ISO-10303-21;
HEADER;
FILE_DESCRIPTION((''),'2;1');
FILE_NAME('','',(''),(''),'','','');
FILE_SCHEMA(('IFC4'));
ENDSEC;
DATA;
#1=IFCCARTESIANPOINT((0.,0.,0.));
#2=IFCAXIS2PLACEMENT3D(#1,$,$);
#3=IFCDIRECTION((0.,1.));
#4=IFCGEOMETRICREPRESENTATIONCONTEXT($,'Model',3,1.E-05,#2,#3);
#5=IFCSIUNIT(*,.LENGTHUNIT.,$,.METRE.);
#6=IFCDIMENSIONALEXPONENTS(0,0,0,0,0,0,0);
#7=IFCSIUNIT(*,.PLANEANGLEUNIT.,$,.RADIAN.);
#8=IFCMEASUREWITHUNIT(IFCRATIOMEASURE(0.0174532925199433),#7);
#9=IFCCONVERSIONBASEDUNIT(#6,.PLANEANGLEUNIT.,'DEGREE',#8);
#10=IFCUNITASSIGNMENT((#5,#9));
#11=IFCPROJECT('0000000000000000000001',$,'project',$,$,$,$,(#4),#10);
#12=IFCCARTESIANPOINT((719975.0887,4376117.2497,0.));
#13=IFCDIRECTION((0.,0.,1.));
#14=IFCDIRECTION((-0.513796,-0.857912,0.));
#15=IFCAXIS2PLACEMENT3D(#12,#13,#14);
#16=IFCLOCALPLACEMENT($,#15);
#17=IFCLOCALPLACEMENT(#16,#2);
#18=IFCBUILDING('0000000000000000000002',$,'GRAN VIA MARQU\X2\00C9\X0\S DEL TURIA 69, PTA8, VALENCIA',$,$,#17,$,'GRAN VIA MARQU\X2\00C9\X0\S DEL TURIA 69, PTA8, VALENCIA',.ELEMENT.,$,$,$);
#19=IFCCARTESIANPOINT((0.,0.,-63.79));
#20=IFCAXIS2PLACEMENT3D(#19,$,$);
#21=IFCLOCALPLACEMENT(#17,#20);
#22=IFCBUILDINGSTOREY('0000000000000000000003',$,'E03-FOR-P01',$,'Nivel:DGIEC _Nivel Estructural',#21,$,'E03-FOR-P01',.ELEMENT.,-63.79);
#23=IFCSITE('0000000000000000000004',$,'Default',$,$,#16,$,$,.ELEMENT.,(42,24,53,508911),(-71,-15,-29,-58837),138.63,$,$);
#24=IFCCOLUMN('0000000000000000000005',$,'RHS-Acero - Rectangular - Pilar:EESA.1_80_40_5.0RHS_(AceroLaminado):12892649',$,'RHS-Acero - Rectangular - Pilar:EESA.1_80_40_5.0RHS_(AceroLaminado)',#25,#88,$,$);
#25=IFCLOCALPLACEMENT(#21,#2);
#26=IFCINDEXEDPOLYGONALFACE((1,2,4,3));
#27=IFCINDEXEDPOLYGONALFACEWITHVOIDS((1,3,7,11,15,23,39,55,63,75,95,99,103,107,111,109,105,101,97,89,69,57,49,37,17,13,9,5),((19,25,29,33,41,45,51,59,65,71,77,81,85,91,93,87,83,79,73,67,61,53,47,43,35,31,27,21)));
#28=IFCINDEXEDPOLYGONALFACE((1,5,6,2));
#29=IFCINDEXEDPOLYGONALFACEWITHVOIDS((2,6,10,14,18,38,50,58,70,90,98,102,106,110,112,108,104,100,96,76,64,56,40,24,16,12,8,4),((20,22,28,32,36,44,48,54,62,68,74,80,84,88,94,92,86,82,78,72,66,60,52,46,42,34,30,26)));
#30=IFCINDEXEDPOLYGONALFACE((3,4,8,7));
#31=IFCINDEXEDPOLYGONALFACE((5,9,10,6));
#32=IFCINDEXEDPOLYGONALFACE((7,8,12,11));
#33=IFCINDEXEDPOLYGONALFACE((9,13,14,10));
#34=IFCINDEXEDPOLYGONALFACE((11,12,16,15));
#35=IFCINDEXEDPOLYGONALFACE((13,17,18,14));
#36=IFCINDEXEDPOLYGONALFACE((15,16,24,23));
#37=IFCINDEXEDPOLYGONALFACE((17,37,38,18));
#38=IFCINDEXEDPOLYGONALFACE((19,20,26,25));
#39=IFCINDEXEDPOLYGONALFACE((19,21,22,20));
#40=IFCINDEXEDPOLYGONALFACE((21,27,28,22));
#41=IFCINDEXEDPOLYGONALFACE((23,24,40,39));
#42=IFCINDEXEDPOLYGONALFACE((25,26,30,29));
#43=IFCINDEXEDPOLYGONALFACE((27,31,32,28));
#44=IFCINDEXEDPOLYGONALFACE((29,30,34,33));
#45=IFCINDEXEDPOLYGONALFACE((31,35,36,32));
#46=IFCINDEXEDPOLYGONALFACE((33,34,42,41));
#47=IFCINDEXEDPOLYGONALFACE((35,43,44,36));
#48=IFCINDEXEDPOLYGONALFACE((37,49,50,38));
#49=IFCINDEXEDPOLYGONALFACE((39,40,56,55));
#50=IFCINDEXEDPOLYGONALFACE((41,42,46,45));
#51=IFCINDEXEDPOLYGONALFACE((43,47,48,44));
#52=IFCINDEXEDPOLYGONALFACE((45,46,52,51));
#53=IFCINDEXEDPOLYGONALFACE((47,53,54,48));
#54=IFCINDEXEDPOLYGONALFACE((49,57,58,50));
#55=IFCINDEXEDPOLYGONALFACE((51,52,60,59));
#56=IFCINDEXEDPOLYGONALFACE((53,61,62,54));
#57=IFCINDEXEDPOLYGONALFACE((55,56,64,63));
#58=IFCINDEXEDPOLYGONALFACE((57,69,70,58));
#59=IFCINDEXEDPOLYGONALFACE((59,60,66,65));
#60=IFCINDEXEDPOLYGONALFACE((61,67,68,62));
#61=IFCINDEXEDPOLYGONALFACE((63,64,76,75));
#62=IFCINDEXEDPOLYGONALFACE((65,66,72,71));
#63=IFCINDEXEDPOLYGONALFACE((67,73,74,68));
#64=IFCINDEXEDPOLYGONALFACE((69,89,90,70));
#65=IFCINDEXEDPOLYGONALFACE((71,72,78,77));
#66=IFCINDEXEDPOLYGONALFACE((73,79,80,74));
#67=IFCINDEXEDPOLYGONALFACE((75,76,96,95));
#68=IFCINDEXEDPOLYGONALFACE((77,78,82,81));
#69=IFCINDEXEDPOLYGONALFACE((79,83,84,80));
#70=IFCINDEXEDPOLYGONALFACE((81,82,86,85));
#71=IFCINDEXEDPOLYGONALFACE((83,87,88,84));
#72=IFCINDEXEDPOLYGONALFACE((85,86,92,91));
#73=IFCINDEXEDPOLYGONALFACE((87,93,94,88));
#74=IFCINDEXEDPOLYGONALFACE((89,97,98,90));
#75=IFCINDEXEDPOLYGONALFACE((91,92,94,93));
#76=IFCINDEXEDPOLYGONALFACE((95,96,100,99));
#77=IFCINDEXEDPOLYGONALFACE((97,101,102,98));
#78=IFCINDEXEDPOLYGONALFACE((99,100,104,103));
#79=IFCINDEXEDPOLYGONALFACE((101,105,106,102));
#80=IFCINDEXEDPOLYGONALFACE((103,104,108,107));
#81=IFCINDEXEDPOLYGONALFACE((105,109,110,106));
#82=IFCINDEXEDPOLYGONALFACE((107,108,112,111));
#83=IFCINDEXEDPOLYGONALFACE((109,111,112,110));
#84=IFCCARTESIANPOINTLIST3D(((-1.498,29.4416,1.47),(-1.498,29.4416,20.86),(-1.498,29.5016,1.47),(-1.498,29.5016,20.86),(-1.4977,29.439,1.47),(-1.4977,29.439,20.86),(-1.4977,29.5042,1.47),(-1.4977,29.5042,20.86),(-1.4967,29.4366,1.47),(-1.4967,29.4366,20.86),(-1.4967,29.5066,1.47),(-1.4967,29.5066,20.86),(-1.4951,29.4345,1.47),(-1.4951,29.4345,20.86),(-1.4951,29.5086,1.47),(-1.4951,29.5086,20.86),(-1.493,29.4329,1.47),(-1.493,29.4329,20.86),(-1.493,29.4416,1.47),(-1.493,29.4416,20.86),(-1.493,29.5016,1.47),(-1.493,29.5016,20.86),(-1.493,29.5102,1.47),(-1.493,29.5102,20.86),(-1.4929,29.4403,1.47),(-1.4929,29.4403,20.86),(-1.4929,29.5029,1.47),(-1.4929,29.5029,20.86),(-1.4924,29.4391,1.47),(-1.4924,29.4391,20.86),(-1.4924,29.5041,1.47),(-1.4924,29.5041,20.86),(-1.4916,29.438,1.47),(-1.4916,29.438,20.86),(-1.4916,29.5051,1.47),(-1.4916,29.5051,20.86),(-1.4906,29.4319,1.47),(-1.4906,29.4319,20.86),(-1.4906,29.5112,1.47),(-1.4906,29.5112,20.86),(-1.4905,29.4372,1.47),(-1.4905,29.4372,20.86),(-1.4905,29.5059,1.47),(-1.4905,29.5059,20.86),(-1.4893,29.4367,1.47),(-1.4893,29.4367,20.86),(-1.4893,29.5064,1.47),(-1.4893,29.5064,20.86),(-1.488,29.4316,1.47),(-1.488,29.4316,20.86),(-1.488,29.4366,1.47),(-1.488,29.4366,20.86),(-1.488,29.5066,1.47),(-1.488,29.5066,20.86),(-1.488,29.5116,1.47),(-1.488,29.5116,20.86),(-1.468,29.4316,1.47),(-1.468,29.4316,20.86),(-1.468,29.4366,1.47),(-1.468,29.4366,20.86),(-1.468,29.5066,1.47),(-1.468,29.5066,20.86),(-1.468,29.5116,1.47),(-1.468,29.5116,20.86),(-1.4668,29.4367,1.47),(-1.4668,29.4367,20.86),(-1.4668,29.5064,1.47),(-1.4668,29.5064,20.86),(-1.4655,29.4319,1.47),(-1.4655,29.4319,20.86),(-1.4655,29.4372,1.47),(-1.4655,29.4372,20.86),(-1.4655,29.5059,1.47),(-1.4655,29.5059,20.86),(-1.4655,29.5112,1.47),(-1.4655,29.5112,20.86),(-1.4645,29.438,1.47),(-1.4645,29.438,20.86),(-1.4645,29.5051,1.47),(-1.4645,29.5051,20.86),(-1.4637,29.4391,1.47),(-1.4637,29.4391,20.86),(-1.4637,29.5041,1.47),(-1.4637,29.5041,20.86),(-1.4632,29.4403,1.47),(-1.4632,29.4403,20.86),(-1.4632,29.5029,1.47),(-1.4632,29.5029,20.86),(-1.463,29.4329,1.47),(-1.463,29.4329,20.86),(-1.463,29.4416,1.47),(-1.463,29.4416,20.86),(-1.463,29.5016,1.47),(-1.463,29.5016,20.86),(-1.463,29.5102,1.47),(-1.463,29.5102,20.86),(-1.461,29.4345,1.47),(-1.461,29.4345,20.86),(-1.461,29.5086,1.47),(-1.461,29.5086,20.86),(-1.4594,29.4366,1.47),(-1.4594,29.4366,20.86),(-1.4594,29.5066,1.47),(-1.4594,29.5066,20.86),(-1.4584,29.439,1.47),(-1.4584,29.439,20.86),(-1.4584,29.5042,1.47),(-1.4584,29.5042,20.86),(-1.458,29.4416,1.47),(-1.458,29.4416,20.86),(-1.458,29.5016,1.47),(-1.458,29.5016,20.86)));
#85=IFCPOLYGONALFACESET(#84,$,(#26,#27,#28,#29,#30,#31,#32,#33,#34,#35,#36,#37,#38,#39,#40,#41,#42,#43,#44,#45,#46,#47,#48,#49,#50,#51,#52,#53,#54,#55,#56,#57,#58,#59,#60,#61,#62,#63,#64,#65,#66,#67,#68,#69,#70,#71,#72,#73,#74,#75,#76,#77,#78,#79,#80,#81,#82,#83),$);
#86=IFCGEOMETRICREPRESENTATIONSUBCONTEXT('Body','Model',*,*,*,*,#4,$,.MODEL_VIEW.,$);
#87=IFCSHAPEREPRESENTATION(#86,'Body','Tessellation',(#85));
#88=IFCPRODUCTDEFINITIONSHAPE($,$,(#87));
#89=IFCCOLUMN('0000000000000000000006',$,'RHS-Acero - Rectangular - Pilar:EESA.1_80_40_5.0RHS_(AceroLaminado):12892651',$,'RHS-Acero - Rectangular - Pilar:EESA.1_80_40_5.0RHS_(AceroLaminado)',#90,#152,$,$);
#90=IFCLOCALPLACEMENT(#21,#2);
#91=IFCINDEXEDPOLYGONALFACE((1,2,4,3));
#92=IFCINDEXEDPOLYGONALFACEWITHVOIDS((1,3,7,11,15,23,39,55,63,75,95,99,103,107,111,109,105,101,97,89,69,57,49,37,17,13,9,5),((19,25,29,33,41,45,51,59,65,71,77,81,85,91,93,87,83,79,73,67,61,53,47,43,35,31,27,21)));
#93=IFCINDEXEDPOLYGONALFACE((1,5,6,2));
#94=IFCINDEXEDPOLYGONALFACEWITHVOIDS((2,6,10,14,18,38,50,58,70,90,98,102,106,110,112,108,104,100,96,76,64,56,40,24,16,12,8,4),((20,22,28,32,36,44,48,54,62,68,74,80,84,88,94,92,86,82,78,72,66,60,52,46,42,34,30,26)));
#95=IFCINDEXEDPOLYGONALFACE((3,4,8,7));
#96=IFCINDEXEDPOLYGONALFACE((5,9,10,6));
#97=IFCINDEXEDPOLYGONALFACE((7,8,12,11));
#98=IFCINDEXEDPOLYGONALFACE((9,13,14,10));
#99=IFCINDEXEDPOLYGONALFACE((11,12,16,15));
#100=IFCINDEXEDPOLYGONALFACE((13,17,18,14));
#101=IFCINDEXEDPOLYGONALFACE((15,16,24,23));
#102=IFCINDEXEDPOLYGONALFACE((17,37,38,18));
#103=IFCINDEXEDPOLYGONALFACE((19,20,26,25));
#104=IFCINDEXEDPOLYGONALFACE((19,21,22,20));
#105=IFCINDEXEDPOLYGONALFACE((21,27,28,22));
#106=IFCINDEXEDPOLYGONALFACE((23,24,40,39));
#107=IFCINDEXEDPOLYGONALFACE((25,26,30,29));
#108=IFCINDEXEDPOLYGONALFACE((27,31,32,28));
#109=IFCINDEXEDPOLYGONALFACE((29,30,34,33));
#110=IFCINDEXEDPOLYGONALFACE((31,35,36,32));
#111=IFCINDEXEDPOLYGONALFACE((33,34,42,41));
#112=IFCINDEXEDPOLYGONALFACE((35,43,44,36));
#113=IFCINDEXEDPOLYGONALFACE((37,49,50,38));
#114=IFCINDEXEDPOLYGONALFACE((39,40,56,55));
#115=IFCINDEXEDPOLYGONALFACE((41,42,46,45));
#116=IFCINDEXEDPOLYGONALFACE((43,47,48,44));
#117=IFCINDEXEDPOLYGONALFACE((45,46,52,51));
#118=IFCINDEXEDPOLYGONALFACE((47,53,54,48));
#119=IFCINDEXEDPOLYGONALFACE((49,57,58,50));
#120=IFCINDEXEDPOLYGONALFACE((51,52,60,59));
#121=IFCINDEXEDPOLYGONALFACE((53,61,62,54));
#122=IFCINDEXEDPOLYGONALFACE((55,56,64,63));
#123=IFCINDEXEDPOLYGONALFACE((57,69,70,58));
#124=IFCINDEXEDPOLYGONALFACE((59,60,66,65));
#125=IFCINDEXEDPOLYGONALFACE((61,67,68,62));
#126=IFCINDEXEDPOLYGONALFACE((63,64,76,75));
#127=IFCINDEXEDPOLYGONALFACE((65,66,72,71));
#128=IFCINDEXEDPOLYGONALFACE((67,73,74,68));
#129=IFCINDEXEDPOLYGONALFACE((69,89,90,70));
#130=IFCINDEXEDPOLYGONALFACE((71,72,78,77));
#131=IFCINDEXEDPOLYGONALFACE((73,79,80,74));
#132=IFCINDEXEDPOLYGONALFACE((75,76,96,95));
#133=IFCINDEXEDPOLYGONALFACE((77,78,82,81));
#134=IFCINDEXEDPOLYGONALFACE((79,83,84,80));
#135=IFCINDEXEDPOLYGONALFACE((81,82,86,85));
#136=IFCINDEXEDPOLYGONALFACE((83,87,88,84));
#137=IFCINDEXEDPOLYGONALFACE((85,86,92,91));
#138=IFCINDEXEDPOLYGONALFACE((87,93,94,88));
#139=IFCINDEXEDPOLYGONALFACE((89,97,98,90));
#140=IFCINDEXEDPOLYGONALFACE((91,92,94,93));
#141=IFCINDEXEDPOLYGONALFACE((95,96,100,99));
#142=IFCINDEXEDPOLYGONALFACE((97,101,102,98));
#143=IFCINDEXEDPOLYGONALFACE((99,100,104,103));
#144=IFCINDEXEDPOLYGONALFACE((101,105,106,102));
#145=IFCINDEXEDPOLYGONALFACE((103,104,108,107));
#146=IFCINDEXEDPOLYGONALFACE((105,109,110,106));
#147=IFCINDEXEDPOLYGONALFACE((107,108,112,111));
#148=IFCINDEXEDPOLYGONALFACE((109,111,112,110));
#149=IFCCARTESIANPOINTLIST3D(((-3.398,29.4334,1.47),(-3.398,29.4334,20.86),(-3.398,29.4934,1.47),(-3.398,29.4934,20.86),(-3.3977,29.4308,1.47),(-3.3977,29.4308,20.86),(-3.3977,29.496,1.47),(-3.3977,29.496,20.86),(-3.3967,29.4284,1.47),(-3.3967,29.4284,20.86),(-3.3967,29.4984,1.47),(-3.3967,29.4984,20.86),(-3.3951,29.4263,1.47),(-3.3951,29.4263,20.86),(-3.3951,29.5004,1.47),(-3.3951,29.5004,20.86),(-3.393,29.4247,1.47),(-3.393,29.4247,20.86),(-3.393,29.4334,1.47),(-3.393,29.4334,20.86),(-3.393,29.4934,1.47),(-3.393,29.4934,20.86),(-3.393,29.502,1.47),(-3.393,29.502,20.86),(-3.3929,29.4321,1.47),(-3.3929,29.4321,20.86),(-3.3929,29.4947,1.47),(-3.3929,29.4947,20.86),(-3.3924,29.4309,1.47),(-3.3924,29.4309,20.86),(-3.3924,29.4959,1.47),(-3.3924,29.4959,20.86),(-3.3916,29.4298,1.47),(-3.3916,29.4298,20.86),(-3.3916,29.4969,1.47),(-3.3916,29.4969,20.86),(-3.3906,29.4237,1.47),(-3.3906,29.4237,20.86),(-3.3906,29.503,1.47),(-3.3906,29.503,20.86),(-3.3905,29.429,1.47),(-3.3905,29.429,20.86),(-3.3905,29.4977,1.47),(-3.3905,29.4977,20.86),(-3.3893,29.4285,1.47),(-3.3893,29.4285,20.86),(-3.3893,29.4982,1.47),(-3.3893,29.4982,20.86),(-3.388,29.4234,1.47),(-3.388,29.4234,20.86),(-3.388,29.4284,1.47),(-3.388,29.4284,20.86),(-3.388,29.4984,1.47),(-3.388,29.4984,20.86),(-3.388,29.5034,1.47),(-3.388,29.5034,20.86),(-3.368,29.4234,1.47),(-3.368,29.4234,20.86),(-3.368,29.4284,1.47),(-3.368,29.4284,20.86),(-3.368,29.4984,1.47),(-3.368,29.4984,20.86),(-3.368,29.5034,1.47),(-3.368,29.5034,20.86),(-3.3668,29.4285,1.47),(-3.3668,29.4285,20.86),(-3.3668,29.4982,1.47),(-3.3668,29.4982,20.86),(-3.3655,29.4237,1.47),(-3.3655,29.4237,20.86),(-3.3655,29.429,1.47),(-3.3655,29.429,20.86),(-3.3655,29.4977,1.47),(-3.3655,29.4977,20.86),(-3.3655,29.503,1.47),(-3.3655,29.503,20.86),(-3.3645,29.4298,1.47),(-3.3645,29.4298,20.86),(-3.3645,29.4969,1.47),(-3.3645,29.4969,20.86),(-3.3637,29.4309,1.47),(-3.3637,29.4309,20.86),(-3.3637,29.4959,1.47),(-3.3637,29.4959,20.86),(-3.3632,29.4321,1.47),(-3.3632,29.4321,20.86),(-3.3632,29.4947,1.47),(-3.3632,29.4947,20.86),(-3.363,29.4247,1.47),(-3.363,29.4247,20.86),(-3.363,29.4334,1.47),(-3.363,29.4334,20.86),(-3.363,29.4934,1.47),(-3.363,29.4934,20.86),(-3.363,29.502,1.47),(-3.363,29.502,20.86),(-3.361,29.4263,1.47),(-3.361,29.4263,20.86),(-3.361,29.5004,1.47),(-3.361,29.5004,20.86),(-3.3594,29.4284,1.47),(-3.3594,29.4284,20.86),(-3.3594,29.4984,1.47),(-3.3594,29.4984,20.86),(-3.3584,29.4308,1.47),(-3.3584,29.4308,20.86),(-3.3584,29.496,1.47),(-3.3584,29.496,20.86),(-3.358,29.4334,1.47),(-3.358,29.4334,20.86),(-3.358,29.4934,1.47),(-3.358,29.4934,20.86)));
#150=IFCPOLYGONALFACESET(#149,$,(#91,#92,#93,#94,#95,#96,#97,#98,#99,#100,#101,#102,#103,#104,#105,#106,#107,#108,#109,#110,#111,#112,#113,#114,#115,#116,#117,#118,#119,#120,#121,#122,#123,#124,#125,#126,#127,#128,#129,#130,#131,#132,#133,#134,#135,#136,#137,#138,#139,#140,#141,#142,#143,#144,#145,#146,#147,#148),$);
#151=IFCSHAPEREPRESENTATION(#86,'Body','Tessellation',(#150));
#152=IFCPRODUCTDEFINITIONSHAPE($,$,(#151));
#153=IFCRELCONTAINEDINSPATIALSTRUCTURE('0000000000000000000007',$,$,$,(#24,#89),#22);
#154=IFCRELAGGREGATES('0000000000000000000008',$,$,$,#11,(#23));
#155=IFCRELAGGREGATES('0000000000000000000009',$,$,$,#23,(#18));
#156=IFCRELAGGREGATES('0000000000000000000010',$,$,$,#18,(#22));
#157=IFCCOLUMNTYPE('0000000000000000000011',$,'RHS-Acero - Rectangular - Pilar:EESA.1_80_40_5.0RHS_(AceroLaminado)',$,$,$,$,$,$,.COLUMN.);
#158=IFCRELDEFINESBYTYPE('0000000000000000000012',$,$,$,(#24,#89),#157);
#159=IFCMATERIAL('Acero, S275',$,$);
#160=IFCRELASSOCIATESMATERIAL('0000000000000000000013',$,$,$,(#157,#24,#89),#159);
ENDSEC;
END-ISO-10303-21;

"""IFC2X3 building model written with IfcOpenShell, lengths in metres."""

from ifc_helpers import new_model, entity, si_unit, converted_unit, direction, frame, frame_2d, origin, place, context, subcontext, project, spatial, polyline, circle_curve, parameter, trimmed, segment, composite_curve, outline, extrude, source, transform, mapped, material, type_object, type_shapes, element, save


model = new_model("IFC2X3")

# Units and contexts
model_context = context("Model", 3, precision=1e-05, world=origin(), true_north=direction((0.0, 1.0)))
body_context = subcontext(model_context, "Body", "Model", "MODEL_VIEW")
ifc_project = project(units=[si_unit("LENGTHUNIT", "METRE"), converted_unit("PLANEANGLEUNIT", "DEGREE", entity("IfcRatioMeasure", 0.0174532925199433), si_unit("PLANEANGLEUNIT", "RADIAN"), dimensions=[0, 0, 0, 0, 0, 0, 0])], contexts=[model_context])

# Site, building, storey
site_placement = place(None, frame((719975.0887, 4376117.2497, 0.0), z_axis=(0.0, 0.0, 1.0), x_axis=(-0.513796, -0.857912, 0.0)))
site = spatial("IfcSite", under=ifc_project, at=site_placement, Name="Default", CompositionType="ELEMENT", RefLatitude=(42, 24, 53, 508911), RefLongitude=(-71, -15, -29, -58837), RefElevation=138.63)
building_placement = place(site_placement, origin())
building = spatial("IfcBuilding", under=site, at=building_placement, Name="GRAN VIA MARQUÉS DEL TURIA 69, PTA8, VALENCIA", LongName="GRAN VIA MARQUÉS DEL TURIA 69, PTA8, VALENCIA", CompositionType="ELEMENT")
storey_placement = place(building_placement, frame((0.0, 0.0, -63.79)))
storey = spatial("IfcBuildingStorey", under=building, at=storey_placement, Name="E03-FOR-P01", ObjectType="Nivel:DGIEC _Nivel Estructural", LongName="E03-FOR-P01", CompositionType="ELEMENT", Elevation=-63.79)

# Columns
ifc_material_1 = material(Name="Acero, S275")
column_type_1 = type_object("IfcColumnType", Name="RHS-Acero - Rectangular - Pilar:EESA.1_80_40_5.0RHS_(AceroLaminado)", PredefinedType="COLUMN", material=ifc_material_1)
shared_shape_1 = source(origin(), body_context, "Body", "SweptSolid", [
    extrude(outline(composite_curve([segment(polyline([(-0.01, -0.04), (0.01, -0.04)]), True, "CONTINUOUS"), segment(trimmed(circle_curve(frame_2d((0.01, -0.03), x_axis=(-1.0, 0.0)), 0.01), [parameter(90.0)], [parameter(180.0)], True, "PARAMETER"), True, "CONTINUOUS"), segment(polyline([(0.02, -0.03), (0.02, 0.03)]), True, "CONTINUOUS"), segment(trimmed(circle_curve(frame_2d((0.01, 0.03), x_axis=(-1.0, 0.0)), 0.01), [parameter(180.0)], [parameter(270.0)], True, "PARAMETER"), True, "CONTINUOUS"), segment(polyline([(0.01, 0.04), (-0.01, 0.04)]), True, "CONTINUOUS"), segment(trimmed(circle_curve(frame_2d((-0.01, 0.03), x_axis=(-1.0, 0.0)), 0.01), [parameter(270.0)], [parameter(360.0)], True, "PARAMETER"), True, "CONTINUOUS"), segment(polyline([(-0.02, 0.03), (-0.02, -0.03)]), True, "CONTINUOUS"), segment(trimmed(circle_curve(frame_2d((-0.01, -0.03), x_axis=(-1.0, 0.0)), 0.01), [parameter(360.0)], [parameter(90.0)], True, "PARAMETER"), True, "CONTINUOUS")], self_intersect=False), holes=[composite_curve([segment(trimmed(circle_curve(frame_2d((-0.01, -0.03), x_axis=(-1.0, 0.0)), 0.005), [parameter(0.0)], [parameter(90.0)], True, "PARAMETER"), False, "CONTINUOUS"), segment(polyline([(-0.015, -0.03), (-0.015, 0.03)]), True, "CONTINUOUS"), segment(trimmed(circle_curve(frame_2d((-0.01, 0.03), x_axis=(-1.0, 0.0)), 0.005), [parameter(270.0)], [parameter(0.0)], True, "PARAMETER"), False, "CONTINUOUS"), segment(polyline([(-0.01, 0.035), (0.01, 0.035)]), True, "CONTINUOUS"), segment(trimmed(circle_curve(frame_2d((0.01, 0.03), x_axis=(-1.0, 0.0)), 0.005), [parameter(180.0)], [parameter(270.0)], True, "PARAMETER"), False, "CONTINUOUS"), segment(polyline([(0.015, 0.03), (0.015, -0.03)]), True, "CONTINUOUS"), segment(trimmed(circle_curve(frame_2d((0.01, -0.03), x_axis=(-1.0, 0.0)), 0.005), [parameter(90.0)], [parameter(180.0)], True, "PARAMETER"), False, "CONTINUOUS"), segment(polyline([(0.01, -0.035), (-0.01, -0.035)]), True, "CONTINUOUS")], self_intersect=False)]), frame((0.0, 0.0, -62.32), z_axis=(0.0, 0.0, 1.0), x_axis=(-1.0, 0.0, 0.0)), (0.0, 0.0, 1.0), 19.39),
])
type_shapes(column_type_1, [shared_shape_1])
for number, where, z_axis, x_axis, name in (
    (1, (-1.478, 29.4716, 63.79), (0.0, 0.0, 1.0), (-1.0, 0.0, 0.0), "RHS-Acero - Rectangular - Pilar:EESA.1_80_40_5.0RHS_(AceroLaminado):12892649"),
    (2, (-3.378, 29.4634, 63.79), (0.0, 0.0, 1.0), (-1.0, 0.0, 0.0), "RHS-Acero - Rectangular - Pilar:EESA.1_80_40_5.0RHS_(AceroLaminado):12892651"),
):
    element("IfcColumn", number, at=place(storey_placement, frame(where, z_axis=z_axis, x_axis=x_axis)), inside=storey, type_object=column_type_1, material=ifc_material_1, Name=name, ObjectType="RHS-Acero - Rectangular - Pilar:EESA.1_80_40_5.0RHS_(AceroLaminado)", context=body_context, shape_type="MappedRepresentation", body=[
        mapped(shared_shape_1, transform((0.0, 0.0, 0.0), scale=1.0)),
    ])

save(model, "model.ifc")
